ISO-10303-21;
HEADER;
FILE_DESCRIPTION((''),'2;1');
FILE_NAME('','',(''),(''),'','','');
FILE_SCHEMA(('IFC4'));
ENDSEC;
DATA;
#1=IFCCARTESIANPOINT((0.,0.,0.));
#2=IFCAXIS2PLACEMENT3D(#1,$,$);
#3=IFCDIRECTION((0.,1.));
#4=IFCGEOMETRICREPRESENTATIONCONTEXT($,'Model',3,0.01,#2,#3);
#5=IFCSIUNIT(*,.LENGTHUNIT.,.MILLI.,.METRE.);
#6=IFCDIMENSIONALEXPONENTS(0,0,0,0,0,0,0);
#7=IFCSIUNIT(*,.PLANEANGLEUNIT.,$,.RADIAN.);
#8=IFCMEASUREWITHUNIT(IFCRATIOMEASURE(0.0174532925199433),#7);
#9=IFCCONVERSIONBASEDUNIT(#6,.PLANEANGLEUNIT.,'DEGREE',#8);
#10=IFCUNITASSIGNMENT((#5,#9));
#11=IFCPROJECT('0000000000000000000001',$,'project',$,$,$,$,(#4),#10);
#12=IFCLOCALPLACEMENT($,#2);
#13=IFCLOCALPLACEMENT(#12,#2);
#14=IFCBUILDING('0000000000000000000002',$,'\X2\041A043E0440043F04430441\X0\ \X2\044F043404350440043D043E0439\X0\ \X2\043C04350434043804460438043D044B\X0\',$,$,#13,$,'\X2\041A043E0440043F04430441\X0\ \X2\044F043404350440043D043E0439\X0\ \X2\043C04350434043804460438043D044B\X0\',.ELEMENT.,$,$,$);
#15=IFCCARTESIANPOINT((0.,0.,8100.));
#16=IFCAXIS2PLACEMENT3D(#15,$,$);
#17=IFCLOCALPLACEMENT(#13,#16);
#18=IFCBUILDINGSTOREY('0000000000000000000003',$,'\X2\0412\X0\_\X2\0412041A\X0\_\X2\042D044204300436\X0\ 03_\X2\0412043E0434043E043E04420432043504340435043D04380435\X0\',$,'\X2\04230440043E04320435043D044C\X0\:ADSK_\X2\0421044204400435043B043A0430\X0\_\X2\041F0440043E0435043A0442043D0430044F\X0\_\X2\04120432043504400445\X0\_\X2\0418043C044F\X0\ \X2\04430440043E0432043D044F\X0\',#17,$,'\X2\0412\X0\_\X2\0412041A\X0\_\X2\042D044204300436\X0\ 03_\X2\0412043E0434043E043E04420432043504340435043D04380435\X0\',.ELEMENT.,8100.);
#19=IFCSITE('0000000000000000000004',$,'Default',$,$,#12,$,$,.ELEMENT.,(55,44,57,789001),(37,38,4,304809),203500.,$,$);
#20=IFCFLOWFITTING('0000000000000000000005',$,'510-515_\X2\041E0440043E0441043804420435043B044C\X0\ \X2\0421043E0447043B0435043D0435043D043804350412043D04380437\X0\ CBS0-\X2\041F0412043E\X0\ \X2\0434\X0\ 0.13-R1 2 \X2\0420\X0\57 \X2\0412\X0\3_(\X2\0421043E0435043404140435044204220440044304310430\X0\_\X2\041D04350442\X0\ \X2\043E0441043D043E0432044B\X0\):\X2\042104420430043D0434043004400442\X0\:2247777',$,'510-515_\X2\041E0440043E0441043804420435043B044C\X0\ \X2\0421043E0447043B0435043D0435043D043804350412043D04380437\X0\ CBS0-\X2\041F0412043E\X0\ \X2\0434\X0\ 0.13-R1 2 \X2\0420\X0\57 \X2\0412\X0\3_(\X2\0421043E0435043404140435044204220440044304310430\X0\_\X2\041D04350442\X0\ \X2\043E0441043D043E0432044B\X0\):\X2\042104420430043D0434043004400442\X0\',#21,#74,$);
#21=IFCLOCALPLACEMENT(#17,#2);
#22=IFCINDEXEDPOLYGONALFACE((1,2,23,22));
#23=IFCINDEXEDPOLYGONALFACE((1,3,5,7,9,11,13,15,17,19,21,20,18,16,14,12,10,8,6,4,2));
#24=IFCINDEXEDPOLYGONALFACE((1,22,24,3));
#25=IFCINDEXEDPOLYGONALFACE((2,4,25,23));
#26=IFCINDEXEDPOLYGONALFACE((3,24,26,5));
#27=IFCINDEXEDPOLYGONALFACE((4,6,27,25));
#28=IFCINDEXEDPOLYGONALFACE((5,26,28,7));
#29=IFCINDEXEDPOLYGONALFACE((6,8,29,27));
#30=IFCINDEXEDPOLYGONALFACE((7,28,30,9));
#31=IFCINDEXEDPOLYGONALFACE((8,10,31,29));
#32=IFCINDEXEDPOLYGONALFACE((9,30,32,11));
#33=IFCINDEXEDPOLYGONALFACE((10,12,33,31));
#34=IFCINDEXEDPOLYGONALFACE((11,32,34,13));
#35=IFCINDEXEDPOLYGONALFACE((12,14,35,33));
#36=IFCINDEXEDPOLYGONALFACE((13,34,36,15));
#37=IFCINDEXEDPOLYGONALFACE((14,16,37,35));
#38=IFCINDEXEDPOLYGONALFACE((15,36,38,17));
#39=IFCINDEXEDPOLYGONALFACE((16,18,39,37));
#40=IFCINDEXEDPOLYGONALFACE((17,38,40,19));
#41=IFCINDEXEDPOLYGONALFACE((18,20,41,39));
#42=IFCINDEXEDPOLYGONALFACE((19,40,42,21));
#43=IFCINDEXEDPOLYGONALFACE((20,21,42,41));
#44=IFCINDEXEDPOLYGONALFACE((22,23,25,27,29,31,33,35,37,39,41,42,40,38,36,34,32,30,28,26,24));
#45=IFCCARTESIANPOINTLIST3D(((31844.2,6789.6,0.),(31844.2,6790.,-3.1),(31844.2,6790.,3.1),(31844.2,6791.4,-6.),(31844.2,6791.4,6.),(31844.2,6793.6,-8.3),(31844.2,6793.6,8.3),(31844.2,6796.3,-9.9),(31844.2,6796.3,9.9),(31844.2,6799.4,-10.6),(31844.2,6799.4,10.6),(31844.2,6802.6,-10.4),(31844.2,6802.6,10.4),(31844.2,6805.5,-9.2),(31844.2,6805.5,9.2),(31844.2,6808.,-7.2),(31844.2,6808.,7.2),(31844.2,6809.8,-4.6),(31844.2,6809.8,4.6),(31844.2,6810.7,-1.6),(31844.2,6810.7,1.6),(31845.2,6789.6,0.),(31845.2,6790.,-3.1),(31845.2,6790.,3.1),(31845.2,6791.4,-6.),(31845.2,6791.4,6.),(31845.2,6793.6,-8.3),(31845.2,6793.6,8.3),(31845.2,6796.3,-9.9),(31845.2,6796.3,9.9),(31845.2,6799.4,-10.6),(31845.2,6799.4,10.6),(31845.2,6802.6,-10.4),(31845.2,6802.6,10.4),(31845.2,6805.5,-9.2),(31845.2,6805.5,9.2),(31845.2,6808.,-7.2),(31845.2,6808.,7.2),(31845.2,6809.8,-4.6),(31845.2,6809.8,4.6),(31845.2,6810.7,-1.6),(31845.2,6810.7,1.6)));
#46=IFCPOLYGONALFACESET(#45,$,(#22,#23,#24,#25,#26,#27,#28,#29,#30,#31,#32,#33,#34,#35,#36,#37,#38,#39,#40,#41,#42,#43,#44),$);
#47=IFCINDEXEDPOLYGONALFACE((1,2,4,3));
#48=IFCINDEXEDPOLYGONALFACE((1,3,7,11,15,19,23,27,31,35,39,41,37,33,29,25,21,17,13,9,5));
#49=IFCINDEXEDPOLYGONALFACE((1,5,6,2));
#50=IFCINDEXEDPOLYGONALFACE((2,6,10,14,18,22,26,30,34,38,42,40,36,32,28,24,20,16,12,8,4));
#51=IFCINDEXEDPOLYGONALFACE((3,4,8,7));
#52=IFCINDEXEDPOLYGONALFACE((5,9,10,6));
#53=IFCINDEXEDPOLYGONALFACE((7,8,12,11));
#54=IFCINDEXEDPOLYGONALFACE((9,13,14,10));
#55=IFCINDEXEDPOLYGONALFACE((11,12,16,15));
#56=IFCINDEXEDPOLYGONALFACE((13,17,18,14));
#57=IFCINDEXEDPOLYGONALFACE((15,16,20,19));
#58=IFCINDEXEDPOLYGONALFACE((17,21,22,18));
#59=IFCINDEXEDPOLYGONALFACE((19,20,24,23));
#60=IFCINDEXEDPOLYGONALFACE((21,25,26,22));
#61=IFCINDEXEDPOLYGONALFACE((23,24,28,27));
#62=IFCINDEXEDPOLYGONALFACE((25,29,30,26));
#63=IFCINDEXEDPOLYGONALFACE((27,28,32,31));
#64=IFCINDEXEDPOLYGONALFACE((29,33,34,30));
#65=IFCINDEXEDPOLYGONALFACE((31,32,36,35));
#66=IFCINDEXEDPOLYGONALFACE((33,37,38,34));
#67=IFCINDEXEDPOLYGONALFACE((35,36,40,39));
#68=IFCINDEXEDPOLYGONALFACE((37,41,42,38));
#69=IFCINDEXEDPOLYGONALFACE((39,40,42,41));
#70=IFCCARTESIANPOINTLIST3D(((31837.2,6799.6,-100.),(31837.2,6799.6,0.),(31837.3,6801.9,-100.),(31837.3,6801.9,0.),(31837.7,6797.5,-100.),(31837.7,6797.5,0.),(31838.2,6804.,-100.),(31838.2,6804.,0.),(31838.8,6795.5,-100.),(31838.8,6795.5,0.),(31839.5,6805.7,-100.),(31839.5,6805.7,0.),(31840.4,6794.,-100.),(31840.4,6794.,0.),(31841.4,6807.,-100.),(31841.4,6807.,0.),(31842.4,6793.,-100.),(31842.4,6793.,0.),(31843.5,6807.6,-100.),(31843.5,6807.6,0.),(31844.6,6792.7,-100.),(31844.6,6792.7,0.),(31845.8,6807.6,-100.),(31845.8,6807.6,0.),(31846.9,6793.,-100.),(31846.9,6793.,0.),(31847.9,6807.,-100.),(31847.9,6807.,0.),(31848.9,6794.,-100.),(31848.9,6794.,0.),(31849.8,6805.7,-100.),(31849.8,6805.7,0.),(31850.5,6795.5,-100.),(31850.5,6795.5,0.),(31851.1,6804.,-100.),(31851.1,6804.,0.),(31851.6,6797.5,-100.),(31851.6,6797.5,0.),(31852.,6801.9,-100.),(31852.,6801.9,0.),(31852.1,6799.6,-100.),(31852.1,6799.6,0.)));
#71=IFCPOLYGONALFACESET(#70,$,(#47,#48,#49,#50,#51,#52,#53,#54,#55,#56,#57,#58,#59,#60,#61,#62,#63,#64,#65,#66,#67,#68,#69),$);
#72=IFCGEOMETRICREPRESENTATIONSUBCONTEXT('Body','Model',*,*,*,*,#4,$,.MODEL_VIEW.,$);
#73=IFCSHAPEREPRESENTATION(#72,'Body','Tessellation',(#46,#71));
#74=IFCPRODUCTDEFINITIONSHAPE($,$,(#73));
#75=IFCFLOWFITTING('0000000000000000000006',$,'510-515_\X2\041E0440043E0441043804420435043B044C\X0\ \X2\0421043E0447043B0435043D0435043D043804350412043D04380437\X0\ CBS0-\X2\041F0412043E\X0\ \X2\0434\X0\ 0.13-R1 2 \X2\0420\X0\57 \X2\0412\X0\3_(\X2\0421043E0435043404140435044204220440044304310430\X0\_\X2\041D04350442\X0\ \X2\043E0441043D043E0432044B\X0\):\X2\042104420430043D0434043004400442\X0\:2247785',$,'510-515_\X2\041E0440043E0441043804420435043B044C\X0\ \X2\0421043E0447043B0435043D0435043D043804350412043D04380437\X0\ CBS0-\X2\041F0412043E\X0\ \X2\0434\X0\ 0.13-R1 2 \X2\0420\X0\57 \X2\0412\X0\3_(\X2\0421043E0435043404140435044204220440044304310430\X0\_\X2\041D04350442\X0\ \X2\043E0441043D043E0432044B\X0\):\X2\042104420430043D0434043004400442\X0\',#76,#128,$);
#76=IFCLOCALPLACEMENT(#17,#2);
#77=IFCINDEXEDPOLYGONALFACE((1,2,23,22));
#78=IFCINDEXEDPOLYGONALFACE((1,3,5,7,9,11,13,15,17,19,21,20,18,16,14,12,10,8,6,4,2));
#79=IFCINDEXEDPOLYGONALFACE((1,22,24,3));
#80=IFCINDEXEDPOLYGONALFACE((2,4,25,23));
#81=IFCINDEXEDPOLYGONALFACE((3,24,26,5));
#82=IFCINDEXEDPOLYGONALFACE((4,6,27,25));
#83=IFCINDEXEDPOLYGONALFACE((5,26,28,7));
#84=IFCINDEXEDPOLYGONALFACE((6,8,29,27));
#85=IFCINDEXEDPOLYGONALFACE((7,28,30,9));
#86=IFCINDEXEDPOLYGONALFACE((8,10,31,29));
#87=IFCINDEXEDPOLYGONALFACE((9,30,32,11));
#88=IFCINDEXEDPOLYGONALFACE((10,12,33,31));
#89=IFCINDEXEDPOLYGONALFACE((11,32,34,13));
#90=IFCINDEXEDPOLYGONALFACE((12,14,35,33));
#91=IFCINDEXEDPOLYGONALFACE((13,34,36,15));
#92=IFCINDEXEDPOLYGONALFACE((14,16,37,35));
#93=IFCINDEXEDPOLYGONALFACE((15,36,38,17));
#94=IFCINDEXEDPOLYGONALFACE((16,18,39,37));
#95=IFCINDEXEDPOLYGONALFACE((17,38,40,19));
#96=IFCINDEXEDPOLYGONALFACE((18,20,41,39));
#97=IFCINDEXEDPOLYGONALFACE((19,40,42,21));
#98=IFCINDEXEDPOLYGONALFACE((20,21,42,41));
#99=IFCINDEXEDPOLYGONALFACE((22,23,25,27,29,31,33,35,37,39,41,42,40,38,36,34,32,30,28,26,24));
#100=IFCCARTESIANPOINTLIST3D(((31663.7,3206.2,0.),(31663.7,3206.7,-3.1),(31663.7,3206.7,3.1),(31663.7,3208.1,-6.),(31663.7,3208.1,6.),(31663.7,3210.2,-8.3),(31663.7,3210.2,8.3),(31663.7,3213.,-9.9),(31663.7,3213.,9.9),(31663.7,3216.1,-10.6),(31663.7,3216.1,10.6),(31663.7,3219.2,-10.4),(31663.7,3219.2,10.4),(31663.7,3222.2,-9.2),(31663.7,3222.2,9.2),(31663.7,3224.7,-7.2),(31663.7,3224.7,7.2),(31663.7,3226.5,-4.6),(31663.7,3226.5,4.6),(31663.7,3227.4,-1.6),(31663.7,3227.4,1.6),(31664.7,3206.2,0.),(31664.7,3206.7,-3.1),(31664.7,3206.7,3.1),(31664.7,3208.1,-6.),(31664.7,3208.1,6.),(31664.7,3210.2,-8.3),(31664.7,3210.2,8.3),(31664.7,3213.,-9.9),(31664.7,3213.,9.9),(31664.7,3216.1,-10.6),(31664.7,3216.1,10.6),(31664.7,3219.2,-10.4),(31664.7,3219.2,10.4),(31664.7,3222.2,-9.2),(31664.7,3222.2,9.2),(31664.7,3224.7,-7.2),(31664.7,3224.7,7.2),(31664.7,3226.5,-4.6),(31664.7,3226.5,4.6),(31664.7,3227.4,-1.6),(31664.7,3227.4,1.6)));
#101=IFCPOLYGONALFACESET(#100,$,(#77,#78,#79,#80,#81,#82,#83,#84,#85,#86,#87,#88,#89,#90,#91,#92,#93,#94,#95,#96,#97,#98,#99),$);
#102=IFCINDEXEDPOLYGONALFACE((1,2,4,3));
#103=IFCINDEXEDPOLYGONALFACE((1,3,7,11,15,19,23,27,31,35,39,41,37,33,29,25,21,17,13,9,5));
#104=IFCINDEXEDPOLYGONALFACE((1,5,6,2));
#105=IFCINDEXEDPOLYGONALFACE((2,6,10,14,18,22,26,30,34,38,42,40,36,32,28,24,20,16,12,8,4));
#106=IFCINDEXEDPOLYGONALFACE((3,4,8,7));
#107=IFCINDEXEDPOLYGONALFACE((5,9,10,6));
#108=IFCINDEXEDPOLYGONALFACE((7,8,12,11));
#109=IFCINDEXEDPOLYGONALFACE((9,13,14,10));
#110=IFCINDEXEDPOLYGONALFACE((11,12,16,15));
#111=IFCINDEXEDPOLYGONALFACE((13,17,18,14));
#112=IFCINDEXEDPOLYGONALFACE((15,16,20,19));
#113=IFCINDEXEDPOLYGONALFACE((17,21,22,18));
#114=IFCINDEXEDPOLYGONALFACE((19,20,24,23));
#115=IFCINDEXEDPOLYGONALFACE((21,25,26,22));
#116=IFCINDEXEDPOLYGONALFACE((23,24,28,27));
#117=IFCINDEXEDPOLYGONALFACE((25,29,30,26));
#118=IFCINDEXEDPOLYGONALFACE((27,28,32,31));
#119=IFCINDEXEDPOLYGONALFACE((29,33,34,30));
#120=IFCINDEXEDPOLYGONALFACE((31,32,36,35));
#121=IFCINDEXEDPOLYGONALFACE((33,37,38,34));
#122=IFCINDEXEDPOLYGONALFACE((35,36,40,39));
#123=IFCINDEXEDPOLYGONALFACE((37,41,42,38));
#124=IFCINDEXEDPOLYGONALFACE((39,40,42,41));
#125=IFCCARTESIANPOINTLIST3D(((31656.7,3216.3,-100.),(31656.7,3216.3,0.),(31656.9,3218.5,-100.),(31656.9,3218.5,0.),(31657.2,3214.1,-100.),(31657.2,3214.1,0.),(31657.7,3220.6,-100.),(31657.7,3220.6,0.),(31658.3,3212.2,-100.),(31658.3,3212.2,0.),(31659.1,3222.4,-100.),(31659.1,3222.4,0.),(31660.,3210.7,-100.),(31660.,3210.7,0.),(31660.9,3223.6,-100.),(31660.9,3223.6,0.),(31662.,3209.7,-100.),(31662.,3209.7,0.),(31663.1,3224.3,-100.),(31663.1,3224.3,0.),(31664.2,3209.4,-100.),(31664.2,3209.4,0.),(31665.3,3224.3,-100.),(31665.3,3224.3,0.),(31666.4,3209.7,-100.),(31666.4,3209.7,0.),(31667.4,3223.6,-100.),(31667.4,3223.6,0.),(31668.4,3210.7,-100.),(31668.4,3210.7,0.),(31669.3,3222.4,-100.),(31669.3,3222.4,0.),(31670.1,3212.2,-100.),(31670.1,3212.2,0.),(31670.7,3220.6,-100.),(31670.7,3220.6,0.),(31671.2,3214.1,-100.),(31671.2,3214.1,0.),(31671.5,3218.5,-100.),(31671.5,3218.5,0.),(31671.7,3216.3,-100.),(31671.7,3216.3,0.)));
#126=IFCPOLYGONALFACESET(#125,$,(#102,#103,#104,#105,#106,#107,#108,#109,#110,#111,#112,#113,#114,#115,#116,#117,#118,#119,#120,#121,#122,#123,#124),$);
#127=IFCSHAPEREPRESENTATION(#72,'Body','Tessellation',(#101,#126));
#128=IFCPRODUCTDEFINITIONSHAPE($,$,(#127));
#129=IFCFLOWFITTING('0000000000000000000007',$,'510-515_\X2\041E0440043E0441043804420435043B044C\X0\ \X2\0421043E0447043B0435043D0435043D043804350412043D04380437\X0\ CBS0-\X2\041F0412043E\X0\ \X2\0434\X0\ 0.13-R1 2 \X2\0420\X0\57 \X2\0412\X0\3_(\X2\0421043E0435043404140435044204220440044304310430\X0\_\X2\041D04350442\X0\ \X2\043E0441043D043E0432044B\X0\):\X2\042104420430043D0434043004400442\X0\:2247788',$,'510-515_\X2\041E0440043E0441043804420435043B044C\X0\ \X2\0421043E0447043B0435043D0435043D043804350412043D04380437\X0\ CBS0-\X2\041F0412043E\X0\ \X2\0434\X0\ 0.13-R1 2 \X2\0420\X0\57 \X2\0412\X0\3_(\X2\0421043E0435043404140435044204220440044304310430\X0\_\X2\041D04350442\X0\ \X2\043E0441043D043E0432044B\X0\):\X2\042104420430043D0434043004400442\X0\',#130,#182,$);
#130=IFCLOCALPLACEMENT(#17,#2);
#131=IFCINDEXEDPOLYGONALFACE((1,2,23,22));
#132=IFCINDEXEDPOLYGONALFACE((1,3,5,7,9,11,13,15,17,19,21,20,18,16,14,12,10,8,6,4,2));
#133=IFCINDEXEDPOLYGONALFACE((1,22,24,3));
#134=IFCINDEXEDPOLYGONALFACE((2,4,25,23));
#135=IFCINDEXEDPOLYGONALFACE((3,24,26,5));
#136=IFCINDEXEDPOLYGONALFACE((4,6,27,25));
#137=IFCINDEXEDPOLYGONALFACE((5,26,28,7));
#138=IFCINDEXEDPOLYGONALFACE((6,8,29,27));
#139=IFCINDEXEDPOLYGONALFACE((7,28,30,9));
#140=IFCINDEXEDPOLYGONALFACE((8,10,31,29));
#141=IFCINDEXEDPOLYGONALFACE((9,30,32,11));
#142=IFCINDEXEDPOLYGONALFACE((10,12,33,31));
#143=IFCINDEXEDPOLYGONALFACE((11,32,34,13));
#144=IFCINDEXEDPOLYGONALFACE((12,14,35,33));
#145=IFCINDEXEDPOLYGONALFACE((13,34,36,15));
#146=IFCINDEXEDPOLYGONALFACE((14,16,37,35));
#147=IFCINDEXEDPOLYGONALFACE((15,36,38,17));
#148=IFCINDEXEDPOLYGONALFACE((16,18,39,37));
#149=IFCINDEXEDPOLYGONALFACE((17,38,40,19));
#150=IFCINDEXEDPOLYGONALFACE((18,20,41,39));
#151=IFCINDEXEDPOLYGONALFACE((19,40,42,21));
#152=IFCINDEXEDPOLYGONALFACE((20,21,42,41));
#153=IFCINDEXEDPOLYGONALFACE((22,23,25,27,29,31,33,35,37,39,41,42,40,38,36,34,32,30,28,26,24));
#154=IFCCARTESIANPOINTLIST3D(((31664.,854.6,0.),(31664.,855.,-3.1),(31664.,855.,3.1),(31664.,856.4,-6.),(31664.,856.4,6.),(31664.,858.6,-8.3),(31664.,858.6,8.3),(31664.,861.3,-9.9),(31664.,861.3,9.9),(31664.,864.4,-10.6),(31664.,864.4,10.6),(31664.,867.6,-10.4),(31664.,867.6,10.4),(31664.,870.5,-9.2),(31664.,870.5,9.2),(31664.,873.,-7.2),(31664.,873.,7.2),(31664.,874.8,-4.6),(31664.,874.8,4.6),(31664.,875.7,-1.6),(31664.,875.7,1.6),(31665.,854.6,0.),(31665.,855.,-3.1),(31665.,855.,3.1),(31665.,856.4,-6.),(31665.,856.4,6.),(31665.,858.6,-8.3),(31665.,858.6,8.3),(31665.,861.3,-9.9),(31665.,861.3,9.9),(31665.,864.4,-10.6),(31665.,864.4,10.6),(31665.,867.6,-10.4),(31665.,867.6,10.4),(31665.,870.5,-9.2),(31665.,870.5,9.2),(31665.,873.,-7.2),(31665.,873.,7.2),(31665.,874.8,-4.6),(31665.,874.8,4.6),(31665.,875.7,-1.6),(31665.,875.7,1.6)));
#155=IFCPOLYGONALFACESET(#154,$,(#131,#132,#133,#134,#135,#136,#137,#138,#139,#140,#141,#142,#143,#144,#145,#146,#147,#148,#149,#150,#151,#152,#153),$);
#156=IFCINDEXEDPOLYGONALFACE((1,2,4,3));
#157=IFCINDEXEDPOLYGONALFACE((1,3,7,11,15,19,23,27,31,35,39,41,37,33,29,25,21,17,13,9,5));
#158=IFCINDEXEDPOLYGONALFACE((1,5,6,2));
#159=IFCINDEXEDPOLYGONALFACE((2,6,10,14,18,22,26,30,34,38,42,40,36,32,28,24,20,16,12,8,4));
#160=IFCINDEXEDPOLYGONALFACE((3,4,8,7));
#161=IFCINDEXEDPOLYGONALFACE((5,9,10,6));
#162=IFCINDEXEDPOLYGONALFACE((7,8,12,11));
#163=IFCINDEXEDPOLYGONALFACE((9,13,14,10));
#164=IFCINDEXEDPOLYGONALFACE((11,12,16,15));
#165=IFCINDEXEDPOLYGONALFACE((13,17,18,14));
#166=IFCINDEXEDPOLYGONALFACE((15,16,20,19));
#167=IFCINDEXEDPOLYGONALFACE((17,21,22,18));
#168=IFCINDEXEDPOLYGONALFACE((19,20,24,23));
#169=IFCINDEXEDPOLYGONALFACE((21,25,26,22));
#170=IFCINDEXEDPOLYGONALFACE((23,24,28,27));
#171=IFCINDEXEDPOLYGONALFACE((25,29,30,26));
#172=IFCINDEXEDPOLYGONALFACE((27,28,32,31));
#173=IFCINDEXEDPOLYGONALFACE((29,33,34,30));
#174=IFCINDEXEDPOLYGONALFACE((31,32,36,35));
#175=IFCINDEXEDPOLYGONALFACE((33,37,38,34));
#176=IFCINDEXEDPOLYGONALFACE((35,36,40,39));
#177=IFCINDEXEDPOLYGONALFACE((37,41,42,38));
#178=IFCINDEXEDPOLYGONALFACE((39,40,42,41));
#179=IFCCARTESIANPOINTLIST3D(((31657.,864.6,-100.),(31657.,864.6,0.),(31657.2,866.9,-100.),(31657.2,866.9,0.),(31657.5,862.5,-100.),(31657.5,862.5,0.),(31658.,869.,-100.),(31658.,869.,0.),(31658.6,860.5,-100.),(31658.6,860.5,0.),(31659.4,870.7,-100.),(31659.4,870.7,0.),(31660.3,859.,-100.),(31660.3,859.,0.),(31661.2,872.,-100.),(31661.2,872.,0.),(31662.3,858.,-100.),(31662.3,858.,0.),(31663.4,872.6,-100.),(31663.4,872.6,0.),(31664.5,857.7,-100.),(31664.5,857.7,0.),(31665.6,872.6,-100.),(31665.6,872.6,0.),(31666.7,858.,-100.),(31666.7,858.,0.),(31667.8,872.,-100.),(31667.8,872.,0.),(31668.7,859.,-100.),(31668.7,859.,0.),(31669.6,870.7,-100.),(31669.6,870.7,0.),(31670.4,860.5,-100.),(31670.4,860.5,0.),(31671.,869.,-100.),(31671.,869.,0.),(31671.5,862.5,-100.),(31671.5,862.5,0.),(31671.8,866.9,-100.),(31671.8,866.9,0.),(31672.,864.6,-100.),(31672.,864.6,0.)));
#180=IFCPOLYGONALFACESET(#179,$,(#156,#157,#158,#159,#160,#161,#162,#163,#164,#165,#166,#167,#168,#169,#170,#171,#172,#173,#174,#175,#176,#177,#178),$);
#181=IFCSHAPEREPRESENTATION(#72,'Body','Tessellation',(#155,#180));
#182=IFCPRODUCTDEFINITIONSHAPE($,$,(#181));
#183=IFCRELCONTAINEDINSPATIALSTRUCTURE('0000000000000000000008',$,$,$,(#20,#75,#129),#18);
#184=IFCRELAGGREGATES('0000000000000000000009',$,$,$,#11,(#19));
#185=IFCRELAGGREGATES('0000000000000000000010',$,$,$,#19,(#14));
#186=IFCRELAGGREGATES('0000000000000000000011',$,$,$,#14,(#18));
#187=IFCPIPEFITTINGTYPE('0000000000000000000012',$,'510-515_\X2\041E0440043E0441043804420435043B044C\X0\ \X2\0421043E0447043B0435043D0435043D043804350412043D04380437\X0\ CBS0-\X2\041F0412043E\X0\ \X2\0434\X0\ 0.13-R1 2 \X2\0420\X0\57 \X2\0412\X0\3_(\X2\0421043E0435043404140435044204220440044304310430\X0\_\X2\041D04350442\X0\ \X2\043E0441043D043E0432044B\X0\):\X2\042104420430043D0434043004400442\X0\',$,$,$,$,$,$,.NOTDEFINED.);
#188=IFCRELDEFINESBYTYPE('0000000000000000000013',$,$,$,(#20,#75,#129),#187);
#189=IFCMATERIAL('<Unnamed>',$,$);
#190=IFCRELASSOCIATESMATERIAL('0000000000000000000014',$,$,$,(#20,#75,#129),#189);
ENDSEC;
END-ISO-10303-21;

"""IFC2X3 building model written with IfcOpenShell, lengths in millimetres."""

from ifc_helpers import new_model, entity, si_unit, converted_unit, direction, frame, origin, origin_2d_with_axis, place, context, subcontext, project, spatial, circle, extrude, source, transform, mapped, material, type_object, type_shapes, element, save


model = new_model("IFC2X3")

# Units and contexts
model_context = context("Model", 3, precision=0.01, world=origin(), true_north=direction((0.0, 1.0)))
body_context = subcontext(model_context, "Body", "Model", "MODEL_VIEW")
ifc_project = project(units=[si_unit("LENGTHUNIT", "METRE", prefix="MILLI"), converted_unit("PLANEANGLEUNIT", "DEGREE", entity("IfcRatioMeasure", 0.0174532925199433), si_unit("PLANEANGLEUNIT", "RADIAN"), dimensions=[0, 0, 0, 0, 0, 0, 0])], contexts=[model_context])

# Site, building, storey
site_placement = place(None, origin())
site = spatial("IfcSite", under=ifc_project, at=site_placement, Name="Default", CompositionType="ELEMENT", RefLatitude=(55, 44, 57, 789001), RefLongitude=(37, 38, 4, 304809), RefElevation=203500.0)
building_placement = place(site_placement, origin())
building = spatial("IfcBuilding", under=site, at=building_placement, Name="Корпус ядерной медицины", LongName="Корпус ядерной медицины", CompositionType="ELEMENT")
storey_placement = place(building_placement, frame((0.0, 0.0, 8100.0)))
storey = spatial("IfcBuildingStorey", under=building, at=storey_placement, Name="В_ВК_Этаж 03_Водоотведение", ObjectType="Уровень:ADSK_Стрелка_Проектная_Вверх_Имя уровня", LongName="В_ВК_Этаж 03_Водоотведение", CompositionType="ELEMENT", Elevation=8100.0)

# Flow fittings
ifc_material = material(Name="<Unnamed>")
pipe_fitting_type = type_object("IfcPipeFittingType", Name="510-515_Ороситель СочленениеВниз CBS0-ПВо д 0.13-R1 2 Р57 В3_(СоедДетТруба_Нет основы):Стандарт", PredefinedType="NOTDEFINED")
shared_shape = source(origin(), body_context, "Body", "SweptSolid", [
    extrude(circle(Radius=10.7, at=origin_2d_with_axis()), frame((-0.5, 0.0, 0.0), z_axis=(1.0, 0.0, 0.0), x_axis=(0.0, 1.0, 0.0)), (0.0, 0.0, 1.0), 1.0),
    extrude(circle(Radius=7.5, at=origin_2d_with_axis()), frame((0.0, 0.0, -100.0), z_axis=(0.0, 0.0, 1.0), x_axis=(0.0, 1.0, 0.0)), (0.0, 0.0, 1.0), 100.0),
])
type_shapes(pipe_fitting_type, [shared_shape])
for number, where, z_axis, x_axis, name in (
    (1, (31844.7, 6800.2, 0.0), (0.0, 0.0, 1.0), (-1.0, 0.0, 0.0), "510-515_Ороситель СочленениеВниз CBS0-ПВо д 0.13-R1 2 Р57 В3_(СоедДетТруба_Нет основы):Стандарт:2247777"),
    (2, (31664.2, 3216.9, 0.0), (0.0, 0.0, 1.0), (-1.0, 0.0, 0.0), "510-515_Ороситель СочленениеВниз CBS0-ПВо д 0.13-R1 2 Р57 В3_(СоедДетТруба_Нет основы):Стандарт:2247785"),
    (3, (31664.5, 865.2, 0.0), (0.0, 0.0, 1.0), (-1.0, 0.0, 0.0), "510-515_Ороситель СочленениеВниз CBS0-ПВо д 0.13-R1 2 Р57 В3_(СоедДетТруба_Нет основы):Стандарт:2247788"),
):
    element("IfcFlowFitting", number, at=place(storey_placement, frame(where, z_axis=z_axis, x_axis=x_axis)), inside=storey, type_object=pipe_fitting_type, material=ifc_material, Name=name, ObjectType="510-515_Ороситель СочленениеВниз CBS0-ПВо д 0.13-R1 2 Р57 В3_(СоедДетТруба_Нет основы):Стандарт", context=body_context, shape_type="MappedRepresentation", body=[
        mapped(shared_shape, transform((0.0, 0.0, 0.0), scale=1.0)),
    ])

save(model, "model.ifc")
